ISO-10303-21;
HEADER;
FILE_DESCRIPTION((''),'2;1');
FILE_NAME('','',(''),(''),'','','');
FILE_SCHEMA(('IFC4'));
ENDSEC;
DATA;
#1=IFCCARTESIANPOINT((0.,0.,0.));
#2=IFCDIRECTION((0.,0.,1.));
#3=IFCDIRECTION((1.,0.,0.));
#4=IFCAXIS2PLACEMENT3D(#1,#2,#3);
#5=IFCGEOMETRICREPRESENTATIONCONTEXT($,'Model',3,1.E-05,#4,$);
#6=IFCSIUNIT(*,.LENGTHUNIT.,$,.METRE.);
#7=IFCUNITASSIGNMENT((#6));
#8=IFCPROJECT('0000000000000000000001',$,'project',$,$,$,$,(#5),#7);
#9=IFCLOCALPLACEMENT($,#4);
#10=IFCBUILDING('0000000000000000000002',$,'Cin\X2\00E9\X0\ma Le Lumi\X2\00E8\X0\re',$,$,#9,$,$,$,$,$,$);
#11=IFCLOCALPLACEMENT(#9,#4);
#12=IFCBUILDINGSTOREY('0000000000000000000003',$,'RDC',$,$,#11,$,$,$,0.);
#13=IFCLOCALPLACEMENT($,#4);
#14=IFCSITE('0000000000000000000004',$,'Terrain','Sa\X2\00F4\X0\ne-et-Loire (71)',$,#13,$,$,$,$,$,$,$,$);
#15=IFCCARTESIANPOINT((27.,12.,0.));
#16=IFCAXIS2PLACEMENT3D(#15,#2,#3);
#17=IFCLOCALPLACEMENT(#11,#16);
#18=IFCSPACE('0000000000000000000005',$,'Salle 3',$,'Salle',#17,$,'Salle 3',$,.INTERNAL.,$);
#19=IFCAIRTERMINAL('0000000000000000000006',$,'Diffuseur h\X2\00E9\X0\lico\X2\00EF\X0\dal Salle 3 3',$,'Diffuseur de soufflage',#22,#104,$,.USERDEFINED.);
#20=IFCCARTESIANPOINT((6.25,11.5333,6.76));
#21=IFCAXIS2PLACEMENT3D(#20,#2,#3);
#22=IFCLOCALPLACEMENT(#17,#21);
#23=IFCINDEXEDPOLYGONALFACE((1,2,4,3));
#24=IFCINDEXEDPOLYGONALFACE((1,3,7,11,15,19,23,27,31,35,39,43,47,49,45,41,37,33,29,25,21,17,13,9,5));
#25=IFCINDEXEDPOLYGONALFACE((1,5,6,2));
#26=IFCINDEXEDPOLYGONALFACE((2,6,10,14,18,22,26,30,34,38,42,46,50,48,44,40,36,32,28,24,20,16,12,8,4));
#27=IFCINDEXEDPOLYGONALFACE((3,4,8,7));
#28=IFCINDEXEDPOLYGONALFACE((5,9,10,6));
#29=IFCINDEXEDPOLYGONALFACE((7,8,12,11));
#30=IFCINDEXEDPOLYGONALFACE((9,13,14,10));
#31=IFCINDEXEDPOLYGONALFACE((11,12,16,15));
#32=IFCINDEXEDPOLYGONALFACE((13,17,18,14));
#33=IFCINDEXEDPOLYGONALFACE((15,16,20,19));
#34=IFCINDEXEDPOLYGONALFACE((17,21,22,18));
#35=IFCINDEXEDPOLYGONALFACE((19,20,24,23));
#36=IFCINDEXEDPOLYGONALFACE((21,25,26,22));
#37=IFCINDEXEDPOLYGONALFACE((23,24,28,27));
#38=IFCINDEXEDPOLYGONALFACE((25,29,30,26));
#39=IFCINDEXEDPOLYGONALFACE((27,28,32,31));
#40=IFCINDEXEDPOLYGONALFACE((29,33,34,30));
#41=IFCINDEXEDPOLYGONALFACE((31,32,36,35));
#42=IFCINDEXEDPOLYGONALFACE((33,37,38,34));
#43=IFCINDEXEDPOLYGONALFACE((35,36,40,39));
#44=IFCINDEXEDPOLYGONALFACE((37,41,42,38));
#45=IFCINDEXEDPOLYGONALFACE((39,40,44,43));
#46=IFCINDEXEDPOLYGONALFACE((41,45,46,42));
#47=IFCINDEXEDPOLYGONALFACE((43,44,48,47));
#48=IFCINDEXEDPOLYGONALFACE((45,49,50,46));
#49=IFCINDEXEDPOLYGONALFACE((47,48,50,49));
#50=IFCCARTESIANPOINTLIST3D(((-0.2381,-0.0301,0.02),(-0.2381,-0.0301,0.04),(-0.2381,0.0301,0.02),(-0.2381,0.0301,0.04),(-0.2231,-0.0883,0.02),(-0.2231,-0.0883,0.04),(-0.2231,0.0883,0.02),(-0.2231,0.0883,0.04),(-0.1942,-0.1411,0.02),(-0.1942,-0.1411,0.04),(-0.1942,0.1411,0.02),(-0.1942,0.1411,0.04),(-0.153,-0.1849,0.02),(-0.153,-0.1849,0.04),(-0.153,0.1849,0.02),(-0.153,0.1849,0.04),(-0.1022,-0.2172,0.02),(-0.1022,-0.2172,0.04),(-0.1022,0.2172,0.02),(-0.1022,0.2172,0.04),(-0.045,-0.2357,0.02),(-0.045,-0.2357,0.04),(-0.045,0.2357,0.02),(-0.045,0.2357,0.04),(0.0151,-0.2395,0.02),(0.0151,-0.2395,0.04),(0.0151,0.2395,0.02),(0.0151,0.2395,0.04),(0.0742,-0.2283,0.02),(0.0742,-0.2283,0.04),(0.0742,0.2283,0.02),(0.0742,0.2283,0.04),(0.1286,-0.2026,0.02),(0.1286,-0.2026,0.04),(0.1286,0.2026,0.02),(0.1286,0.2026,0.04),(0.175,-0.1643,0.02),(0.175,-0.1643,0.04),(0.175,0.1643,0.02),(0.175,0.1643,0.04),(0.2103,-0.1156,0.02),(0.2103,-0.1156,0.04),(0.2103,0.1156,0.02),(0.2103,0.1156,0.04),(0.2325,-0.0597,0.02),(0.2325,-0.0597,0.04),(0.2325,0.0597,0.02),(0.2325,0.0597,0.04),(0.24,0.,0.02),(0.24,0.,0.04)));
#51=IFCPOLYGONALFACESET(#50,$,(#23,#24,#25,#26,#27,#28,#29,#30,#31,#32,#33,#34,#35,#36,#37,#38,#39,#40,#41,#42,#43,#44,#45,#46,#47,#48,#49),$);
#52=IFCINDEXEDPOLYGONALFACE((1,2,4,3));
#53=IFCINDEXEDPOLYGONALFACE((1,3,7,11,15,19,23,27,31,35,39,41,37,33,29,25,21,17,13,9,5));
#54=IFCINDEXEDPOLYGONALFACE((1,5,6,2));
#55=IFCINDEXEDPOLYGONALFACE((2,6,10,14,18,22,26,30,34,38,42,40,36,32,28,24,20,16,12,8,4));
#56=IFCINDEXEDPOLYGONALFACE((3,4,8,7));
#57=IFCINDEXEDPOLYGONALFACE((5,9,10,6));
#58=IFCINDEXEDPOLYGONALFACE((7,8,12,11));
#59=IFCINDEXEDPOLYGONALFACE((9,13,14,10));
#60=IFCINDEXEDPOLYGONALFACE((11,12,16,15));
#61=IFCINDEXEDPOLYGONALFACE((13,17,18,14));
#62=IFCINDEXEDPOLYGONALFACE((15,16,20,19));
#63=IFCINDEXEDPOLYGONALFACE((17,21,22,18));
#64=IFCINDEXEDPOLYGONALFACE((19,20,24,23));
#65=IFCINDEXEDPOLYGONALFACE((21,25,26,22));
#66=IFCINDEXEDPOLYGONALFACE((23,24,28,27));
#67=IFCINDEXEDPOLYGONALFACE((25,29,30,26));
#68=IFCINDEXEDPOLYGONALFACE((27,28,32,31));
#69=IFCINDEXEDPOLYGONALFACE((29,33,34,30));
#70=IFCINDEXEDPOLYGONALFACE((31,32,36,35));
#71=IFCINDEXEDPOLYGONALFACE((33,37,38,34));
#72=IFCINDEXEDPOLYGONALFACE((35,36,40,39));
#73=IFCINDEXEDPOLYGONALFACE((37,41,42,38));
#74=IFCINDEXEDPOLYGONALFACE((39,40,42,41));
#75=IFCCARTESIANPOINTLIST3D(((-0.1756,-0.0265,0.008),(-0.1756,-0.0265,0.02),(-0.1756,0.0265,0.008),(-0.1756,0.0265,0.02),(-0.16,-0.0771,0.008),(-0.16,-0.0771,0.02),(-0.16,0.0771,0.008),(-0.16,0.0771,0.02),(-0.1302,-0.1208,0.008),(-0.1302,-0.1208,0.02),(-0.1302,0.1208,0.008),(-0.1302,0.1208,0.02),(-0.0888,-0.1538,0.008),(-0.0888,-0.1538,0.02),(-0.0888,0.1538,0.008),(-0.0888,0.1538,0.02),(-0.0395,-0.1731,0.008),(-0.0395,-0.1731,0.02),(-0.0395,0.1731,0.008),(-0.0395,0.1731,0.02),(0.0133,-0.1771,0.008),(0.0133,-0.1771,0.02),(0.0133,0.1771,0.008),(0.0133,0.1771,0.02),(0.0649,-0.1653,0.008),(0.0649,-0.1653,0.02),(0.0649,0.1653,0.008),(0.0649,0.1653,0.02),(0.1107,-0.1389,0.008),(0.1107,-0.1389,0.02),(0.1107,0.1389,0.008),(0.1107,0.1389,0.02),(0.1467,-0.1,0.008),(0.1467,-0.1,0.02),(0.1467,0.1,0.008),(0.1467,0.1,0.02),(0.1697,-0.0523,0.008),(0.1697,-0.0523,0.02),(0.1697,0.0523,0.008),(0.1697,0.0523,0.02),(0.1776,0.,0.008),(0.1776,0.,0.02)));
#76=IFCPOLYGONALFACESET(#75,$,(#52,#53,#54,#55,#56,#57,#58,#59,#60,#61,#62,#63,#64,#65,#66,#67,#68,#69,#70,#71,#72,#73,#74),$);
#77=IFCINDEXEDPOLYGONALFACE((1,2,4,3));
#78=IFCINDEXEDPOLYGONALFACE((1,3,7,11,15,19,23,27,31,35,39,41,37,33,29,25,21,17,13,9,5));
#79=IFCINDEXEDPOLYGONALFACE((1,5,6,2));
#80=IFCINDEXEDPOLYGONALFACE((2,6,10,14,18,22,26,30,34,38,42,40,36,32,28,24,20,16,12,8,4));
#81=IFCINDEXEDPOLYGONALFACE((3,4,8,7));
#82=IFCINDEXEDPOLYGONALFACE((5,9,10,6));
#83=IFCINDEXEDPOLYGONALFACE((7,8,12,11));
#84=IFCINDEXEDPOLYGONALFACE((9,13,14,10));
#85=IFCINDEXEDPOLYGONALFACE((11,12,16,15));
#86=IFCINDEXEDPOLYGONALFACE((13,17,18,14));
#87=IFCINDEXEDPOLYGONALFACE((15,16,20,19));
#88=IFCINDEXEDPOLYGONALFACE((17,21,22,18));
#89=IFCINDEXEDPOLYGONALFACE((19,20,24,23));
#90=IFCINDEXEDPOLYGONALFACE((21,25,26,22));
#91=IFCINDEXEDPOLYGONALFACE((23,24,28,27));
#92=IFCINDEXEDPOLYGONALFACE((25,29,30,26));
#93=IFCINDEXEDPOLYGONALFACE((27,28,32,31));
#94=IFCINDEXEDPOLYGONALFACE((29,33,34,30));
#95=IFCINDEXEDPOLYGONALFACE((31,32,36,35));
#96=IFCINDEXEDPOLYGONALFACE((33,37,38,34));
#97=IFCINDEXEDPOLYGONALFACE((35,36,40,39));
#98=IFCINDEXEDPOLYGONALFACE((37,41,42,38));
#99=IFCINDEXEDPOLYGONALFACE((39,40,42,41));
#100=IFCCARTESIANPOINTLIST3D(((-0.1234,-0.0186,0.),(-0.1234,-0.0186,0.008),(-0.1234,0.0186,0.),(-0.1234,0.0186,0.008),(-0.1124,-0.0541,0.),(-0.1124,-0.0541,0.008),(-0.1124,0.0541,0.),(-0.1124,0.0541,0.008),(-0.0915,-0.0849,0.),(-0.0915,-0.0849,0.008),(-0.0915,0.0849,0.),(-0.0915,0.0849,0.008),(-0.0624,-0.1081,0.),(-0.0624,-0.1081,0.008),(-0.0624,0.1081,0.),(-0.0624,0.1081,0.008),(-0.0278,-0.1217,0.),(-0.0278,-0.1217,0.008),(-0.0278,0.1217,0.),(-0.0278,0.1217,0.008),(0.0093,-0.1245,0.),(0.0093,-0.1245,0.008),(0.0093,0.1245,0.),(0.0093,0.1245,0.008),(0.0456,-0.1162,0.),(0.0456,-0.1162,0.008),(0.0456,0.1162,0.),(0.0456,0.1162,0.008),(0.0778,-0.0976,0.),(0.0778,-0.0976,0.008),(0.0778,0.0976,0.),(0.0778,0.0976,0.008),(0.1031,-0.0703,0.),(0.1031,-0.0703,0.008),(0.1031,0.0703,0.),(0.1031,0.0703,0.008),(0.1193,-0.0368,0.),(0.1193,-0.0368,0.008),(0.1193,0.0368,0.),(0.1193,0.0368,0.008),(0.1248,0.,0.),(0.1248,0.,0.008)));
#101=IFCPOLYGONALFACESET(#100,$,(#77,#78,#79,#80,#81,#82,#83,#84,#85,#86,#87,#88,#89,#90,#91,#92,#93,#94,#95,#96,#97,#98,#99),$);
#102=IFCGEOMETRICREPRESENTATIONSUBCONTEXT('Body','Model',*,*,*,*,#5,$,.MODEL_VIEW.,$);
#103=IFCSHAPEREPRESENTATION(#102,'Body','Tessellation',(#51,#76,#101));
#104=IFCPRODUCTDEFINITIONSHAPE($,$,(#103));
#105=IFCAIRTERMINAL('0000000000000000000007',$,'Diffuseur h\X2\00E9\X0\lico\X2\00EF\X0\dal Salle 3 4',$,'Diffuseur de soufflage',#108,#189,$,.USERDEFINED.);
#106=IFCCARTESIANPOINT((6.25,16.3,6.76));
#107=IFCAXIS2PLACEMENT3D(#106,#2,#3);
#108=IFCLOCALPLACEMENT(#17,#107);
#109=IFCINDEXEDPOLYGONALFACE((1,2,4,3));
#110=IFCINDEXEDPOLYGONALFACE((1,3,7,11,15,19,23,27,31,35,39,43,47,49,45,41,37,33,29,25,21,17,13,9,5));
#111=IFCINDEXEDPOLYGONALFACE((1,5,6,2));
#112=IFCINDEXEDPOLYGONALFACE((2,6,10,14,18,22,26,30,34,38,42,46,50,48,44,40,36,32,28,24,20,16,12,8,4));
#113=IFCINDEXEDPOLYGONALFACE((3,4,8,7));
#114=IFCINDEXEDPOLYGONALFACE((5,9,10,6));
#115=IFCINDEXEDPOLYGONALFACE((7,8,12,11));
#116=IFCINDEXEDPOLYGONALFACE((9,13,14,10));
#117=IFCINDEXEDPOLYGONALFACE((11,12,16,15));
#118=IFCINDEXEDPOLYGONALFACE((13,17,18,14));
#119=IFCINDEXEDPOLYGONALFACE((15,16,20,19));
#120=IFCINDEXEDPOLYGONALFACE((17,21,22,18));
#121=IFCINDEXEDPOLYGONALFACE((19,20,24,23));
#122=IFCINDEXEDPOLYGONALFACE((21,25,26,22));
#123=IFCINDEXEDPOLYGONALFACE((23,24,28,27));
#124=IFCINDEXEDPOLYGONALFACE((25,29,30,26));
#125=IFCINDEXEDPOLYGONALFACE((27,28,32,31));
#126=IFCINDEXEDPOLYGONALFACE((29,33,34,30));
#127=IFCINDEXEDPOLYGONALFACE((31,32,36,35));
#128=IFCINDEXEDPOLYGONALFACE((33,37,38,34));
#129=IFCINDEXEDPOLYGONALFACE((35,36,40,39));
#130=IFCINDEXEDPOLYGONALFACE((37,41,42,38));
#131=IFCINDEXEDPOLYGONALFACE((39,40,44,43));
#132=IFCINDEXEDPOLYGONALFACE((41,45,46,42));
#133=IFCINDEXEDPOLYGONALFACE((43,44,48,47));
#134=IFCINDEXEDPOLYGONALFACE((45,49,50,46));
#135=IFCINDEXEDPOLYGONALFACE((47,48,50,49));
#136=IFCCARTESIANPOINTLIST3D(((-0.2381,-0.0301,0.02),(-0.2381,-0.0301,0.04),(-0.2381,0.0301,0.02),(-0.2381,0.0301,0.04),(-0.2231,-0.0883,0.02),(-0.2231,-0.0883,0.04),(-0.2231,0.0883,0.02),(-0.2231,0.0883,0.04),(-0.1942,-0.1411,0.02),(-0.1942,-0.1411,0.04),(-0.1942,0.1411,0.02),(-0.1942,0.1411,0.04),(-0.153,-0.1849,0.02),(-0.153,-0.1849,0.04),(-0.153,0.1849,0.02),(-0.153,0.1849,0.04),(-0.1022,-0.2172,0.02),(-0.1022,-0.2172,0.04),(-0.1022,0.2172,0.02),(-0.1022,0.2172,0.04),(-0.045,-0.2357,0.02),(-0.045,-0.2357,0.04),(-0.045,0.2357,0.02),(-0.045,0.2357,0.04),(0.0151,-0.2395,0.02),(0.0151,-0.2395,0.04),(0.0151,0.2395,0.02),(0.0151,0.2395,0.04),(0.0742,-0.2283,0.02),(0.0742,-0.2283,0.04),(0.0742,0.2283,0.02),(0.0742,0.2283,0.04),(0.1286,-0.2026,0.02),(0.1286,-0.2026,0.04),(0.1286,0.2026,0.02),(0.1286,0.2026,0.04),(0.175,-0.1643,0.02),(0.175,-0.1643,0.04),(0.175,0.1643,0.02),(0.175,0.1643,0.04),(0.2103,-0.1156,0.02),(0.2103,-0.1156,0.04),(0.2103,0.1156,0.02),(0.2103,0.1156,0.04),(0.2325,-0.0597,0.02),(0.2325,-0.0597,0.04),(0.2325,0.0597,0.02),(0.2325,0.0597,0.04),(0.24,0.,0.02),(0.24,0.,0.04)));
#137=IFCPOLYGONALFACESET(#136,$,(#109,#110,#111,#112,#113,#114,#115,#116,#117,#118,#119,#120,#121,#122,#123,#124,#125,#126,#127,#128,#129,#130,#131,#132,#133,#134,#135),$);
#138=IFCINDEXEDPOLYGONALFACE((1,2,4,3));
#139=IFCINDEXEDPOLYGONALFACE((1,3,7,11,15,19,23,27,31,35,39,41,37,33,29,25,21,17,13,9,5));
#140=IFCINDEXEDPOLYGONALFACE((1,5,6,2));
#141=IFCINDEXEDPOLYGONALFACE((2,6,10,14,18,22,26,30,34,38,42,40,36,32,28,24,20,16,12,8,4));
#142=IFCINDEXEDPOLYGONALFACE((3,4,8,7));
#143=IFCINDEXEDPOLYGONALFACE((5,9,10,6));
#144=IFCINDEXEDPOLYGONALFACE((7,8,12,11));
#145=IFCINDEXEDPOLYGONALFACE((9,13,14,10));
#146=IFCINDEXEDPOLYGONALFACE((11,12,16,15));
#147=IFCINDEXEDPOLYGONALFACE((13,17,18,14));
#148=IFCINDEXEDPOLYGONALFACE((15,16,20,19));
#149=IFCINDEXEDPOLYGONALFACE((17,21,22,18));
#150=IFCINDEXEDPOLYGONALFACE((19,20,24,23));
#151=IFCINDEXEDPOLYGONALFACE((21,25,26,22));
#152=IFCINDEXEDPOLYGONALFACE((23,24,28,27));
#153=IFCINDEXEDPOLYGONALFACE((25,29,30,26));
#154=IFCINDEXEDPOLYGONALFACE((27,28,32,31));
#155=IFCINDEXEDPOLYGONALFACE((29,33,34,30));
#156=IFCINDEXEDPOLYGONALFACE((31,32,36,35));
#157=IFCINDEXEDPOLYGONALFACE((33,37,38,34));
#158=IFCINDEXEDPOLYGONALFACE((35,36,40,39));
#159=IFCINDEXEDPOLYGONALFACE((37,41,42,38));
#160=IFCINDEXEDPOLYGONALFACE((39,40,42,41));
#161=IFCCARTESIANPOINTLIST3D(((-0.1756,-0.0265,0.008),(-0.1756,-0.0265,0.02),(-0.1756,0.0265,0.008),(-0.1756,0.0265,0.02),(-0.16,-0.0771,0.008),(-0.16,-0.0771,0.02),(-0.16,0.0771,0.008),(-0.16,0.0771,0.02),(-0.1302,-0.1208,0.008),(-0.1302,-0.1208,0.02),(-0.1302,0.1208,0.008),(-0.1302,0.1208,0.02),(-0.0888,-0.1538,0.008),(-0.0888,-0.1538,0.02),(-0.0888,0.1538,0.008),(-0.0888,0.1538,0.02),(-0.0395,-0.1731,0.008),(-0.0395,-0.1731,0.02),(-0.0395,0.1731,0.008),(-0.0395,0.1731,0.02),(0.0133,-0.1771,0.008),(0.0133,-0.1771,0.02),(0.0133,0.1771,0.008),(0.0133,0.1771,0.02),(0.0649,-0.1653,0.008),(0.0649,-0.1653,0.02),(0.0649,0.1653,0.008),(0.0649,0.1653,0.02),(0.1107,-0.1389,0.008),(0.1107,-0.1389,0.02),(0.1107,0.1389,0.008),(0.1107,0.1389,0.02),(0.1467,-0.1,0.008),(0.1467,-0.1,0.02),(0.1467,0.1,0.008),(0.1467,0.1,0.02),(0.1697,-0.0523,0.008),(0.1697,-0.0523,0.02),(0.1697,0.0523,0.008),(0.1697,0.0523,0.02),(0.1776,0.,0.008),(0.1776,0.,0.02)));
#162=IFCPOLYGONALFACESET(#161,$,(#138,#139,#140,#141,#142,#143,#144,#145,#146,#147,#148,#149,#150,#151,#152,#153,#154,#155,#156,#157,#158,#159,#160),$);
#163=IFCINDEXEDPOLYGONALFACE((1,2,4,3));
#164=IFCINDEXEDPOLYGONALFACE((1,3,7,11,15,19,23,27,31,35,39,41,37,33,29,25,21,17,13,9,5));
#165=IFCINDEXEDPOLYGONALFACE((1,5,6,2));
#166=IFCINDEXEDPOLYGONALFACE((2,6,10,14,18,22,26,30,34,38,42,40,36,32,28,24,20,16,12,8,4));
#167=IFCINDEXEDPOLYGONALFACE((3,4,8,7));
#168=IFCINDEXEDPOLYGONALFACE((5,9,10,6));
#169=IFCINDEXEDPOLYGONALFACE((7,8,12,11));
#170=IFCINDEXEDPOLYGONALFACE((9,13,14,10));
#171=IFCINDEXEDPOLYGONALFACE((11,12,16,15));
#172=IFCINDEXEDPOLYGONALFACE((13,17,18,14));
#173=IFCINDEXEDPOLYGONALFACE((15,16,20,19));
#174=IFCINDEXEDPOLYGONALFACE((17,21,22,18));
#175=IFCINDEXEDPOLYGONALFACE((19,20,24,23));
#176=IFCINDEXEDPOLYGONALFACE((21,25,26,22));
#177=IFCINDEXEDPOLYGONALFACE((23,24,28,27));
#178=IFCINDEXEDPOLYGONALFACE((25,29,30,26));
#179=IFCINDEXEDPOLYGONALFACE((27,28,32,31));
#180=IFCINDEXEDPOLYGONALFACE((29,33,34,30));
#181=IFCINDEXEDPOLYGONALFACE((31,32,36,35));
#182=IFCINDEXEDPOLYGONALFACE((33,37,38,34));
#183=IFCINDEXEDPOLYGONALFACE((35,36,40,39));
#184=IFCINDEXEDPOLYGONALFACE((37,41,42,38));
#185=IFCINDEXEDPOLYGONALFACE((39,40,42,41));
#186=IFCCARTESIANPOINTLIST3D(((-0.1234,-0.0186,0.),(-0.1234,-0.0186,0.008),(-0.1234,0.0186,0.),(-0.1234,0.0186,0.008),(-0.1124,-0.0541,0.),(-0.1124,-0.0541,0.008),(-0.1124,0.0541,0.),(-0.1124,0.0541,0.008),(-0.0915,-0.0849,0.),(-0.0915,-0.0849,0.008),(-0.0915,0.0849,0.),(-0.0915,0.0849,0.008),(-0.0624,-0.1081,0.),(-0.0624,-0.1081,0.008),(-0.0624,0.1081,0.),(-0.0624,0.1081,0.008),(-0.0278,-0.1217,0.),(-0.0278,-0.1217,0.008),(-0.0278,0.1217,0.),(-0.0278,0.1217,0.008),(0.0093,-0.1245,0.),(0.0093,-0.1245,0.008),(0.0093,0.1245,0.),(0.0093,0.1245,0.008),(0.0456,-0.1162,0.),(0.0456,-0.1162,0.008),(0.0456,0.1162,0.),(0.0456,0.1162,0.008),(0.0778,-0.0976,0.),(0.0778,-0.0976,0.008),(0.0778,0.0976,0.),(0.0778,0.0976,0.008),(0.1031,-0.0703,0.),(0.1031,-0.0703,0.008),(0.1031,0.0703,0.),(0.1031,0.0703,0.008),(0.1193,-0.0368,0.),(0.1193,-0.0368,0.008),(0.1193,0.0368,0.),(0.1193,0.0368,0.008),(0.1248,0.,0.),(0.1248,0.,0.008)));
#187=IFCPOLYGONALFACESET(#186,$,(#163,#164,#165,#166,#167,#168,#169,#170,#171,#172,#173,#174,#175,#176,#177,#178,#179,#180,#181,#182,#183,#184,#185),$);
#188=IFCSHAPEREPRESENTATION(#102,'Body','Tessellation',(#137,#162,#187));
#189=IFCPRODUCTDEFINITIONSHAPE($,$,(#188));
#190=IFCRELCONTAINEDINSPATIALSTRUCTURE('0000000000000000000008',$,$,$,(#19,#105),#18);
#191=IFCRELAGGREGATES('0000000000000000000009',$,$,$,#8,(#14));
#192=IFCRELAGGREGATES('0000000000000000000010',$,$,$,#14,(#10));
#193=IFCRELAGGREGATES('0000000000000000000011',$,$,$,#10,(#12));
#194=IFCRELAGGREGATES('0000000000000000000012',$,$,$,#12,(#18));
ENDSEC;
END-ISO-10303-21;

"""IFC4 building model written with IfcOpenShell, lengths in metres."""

from ifc_helpers import new_model, si_unit, frame, origin_with_axes, place, context, subcontext, project, spatial, circle, extrude, element, save


model = new_model("IFC4")

# Units and contexts
model_context = context("Model", 3, precision=1e-05, world=origin_with_axes())
body_context = subcontext(model_context, "Body", "Model", "MODEL_VIEW")
ifc_project = project(units=[si_unit("LENGTHUNIT", "METRE")], contexts=[model_context])

# Site, building, storey
site_placement = place(None, origin_with_axes())
site = spatial("IfcSite", under=ifc_project, at=site_placement, Name="Terrain", Description="Saône-et-Loire (71)")
building_placement = place(None, origin_with_axes())
building = spatial("IfcBuilding", under=site, at=building_placement, Name="Cinéma Le Lumière")
storey_placement = place(building_placement, origin_with_axes())
storey = spatial("IfcBuildingStorey", under=building, at=storey_placement, Name="RDC", Elevation=0.0)

# Shared definitions
space_1_placement = place(storey_placement, frame((27.0, 12.0, 0.0), z_axis=(0.0, 0.0, 1.0), x_axis=(1.0, 0.0, 0.0)))
space_1 = spatial("IfcSpace", under=storey, at=space_1_placement, Name="Salle 3", ObjectType="Salle", LongName="Salle 3", PredefinedType="INTERNAL")

# Air terminals
for number, where, z_axis, x_axis, name in (
    (1, (6.25, 11.5333, 6.76), (0.0, 0.0, 1.0), (1.0, 0.0, 0.0), "Diffuseur hélicoïdal Salle 3 3"),
    (2, (6.25, 16.3, 6.76), (0.0, 0.0, 1.0), (1.0, 0.0, 0.0), "Diffuseur hélicoïdal Salle 3 4"),
):
    element("IfcAirTerminal", number, at=place(space_1_placement, frame(where, z_axis=z_axis, x_axis=x_axis)), inside=space_1, Name=name, ObjectType="Diffuseur de soufflage", PredefinedType="USERDEFINED", context=body_context, shape_type="SweptSolid", body=[
        extrude(circle(Radius=0.24), frame((0.0, 0.0, 0.02), z_axis=(0.0, 0.0, 1.0), x_axis=(1.0, 0.0, 0.0)), (0.0, 0.0, 1.0), 0.02),
        extrude(circle(Radius=0.1776), frame((0.0, 0.0, 0.008), z_axis=(0.0, 0.0, 1.0), x_axis=(1.0, 0.0, 0.0)), (0.0, 0.0, 1.0), 0.012),
        extrude(circle(Radius=0.1248), origin_with_axes(), (0.0, 0.0, 1.0), 0.008),
    ])

save(model, "model.ifc")
